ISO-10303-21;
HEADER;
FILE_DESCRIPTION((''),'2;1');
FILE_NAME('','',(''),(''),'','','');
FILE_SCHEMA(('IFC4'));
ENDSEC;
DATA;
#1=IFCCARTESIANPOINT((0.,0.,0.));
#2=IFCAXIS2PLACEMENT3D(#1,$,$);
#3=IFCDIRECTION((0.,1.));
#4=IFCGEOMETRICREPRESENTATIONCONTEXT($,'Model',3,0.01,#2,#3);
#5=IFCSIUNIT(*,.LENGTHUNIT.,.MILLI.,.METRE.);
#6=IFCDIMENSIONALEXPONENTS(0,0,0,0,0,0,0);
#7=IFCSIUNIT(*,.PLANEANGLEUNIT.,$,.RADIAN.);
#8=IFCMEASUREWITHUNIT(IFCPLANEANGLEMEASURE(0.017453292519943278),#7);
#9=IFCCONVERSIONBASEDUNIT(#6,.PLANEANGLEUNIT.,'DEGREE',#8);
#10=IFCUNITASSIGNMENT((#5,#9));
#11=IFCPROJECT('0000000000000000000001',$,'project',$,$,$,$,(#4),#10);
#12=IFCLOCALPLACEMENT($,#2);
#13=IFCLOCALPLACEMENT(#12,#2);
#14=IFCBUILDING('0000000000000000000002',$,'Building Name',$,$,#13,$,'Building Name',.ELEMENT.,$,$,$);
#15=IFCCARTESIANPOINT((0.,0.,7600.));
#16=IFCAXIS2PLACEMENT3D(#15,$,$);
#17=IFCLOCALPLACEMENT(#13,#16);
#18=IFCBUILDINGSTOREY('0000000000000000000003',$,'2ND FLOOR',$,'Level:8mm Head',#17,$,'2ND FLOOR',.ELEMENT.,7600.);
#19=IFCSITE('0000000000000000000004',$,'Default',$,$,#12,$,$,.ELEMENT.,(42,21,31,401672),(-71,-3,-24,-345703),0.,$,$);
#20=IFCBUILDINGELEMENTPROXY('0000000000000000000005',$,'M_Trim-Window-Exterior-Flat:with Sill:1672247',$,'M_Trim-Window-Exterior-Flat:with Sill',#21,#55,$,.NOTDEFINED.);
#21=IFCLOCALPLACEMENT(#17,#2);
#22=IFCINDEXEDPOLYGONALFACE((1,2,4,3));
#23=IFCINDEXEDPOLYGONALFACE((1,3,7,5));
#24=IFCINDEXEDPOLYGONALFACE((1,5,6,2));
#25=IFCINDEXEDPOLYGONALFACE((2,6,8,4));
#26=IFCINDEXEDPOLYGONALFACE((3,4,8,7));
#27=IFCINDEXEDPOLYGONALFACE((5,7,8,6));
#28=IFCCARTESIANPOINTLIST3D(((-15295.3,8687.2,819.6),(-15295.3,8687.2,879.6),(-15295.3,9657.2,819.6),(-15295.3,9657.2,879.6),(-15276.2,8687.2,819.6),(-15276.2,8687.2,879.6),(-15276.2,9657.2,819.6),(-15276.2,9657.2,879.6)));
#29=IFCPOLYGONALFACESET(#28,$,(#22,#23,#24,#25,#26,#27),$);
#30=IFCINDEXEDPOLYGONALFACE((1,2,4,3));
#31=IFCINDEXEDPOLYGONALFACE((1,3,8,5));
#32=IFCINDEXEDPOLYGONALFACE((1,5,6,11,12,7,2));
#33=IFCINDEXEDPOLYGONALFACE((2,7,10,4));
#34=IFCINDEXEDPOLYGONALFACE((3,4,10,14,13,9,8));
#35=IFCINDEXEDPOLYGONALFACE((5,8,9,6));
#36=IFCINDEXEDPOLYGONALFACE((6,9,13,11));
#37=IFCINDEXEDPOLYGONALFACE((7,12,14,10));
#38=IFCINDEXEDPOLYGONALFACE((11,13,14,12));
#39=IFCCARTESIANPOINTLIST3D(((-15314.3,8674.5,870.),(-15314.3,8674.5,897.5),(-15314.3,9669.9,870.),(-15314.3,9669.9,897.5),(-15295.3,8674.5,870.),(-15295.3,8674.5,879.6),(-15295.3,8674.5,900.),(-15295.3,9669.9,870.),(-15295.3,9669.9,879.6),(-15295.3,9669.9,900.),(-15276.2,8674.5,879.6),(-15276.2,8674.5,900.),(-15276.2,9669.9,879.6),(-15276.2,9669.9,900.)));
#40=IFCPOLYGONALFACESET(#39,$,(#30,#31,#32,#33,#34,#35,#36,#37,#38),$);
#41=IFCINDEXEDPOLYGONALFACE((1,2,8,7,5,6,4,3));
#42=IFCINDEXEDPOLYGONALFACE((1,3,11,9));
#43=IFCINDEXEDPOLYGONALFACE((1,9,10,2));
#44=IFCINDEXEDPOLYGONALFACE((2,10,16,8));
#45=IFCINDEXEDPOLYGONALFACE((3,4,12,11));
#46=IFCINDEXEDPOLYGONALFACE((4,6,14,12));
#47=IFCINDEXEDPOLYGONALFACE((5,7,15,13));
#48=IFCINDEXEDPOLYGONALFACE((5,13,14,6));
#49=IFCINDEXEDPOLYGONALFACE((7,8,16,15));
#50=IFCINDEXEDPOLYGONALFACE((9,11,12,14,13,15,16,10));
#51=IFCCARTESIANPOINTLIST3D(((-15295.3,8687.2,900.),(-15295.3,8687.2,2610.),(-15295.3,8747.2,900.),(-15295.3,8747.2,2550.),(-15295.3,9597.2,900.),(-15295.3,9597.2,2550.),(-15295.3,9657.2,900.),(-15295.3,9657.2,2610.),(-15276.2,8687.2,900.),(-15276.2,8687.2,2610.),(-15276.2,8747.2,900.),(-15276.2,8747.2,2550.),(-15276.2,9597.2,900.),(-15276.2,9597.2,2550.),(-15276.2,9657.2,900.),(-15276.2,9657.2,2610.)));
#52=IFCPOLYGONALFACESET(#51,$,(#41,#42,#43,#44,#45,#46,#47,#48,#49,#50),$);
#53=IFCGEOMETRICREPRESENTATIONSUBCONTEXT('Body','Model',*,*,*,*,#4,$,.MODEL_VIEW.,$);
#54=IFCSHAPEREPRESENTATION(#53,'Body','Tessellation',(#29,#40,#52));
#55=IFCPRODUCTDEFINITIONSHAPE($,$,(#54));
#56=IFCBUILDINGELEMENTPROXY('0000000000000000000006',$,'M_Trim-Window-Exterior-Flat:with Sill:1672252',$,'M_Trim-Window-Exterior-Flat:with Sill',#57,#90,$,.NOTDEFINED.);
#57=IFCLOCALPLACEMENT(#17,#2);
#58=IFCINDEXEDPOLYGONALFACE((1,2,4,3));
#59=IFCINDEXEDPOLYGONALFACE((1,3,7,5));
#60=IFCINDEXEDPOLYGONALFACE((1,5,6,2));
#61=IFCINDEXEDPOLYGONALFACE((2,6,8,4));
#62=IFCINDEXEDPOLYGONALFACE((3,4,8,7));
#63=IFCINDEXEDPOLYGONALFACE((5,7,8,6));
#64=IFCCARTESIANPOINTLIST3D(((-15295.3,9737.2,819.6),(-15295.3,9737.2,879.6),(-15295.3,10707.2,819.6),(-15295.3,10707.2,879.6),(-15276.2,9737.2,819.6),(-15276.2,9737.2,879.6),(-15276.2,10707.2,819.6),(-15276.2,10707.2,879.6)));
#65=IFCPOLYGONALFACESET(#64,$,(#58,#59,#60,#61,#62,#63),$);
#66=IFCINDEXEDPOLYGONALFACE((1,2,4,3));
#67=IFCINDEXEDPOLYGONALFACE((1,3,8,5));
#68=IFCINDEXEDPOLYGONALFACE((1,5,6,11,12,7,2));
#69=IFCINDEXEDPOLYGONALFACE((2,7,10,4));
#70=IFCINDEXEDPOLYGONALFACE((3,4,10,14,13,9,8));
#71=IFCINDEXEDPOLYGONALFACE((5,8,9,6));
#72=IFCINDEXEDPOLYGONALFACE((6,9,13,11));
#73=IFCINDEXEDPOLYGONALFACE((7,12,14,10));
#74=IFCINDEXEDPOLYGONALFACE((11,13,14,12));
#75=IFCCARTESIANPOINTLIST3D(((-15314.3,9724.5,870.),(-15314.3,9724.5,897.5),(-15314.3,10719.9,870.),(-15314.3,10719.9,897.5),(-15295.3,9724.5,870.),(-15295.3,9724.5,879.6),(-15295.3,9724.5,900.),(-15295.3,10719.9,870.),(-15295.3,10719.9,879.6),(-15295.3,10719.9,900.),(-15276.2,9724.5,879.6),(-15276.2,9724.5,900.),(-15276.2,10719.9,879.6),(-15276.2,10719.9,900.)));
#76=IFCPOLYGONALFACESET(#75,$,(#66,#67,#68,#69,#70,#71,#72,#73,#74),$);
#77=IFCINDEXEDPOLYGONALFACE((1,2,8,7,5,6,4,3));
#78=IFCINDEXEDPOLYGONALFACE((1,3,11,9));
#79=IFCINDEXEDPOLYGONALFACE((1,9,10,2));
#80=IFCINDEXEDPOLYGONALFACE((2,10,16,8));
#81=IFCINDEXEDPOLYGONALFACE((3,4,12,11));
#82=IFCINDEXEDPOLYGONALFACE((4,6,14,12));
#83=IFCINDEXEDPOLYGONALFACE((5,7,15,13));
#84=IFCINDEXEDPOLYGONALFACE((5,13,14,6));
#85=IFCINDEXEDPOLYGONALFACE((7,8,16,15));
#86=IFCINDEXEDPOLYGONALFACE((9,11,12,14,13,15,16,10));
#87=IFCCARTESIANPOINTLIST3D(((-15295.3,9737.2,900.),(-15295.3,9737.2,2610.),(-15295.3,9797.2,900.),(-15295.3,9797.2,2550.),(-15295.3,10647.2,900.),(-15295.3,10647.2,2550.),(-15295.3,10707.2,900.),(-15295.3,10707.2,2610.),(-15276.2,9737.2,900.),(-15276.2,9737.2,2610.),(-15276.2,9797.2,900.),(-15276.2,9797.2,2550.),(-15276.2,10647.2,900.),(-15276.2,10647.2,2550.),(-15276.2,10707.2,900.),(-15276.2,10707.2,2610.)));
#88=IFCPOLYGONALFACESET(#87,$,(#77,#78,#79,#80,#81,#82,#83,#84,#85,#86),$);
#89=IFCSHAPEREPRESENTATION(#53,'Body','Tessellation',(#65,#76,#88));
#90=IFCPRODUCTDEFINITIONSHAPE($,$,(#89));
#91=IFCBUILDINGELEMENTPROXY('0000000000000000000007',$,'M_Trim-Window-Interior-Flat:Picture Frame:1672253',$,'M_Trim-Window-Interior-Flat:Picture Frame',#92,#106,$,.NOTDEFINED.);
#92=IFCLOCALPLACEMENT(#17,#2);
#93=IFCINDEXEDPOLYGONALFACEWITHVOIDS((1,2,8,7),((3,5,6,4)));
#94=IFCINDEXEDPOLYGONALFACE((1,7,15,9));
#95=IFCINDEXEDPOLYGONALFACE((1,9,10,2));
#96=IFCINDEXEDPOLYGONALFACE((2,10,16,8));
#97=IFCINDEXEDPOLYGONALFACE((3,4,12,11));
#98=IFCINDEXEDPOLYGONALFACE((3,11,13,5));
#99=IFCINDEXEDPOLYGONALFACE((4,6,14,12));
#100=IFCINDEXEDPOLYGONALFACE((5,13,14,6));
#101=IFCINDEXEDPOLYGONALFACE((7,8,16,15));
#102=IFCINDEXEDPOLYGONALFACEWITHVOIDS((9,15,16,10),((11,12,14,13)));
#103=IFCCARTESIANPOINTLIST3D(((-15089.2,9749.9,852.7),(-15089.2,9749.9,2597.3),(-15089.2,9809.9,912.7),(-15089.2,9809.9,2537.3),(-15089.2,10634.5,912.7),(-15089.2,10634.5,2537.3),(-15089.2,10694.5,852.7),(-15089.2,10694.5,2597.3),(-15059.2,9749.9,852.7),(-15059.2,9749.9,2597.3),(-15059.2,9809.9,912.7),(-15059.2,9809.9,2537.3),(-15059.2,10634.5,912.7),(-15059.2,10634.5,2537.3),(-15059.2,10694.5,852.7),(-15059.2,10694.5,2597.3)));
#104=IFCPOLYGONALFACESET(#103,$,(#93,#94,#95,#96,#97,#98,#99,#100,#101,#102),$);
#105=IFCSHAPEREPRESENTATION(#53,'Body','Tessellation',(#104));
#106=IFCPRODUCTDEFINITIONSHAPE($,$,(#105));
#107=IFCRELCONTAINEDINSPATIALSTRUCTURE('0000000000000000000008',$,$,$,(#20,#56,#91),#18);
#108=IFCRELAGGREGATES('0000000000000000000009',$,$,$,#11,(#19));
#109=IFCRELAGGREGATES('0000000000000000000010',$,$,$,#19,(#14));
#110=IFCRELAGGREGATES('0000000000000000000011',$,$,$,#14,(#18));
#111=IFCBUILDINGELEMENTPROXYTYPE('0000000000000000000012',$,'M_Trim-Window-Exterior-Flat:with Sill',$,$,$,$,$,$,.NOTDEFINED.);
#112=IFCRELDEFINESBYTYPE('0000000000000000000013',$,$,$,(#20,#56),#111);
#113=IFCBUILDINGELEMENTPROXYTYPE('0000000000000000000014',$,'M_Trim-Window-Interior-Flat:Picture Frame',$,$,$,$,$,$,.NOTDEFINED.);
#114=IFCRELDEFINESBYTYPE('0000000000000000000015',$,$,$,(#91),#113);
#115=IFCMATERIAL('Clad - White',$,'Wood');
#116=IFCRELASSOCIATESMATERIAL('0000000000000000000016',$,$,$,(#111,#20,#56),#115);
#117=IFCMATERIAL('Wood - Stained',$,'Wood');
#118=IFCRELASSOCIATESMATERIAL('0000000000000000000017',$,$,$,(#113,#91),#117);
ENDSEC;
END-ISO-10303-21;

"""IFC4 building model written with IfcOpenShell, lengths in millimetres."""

from ifc_helpers import new_model, entity, si_unit, converted_unit, direction, frame, origin, place, context, subcontext, project, spatial, indexed_curve, outline, extrude, source, transform, mapped, material, type_object, type_shapes, element, save


model = new_model("IFC4")

# Units and contexts
model_context = context("Model", 3, precision=0.01, world=origin(), true_north=direction((0.0, 1.0)))
body_context = subcontext(model_context, "Body", "Model", "MODEL_VIEW")
ifc_project = project(units=[si_unit("LENGTHUNIT", "METRE", prefix="MILLI"), converted_unit("PLANEANGLEUNIT", "DEGREE", entity("IfcPlaneAngleMeasure", 0.017453292519943278), si_unit("PLANEANGLEUNIT", "RADIAN"), dimensions=[0, 0, 0, 0, 0, 0, 0])], contexts=[model_context])

# Site, building, storey
site_placement = place(None, origin())
site = spatial("IfcSite", under=ifc_project, at=site_placement, Name="Default", CompositionType="ELEMENT", RefLatitude=(42, 21, 31, 401672), RefLongitude=(-71, -3, -24, -345703), RefElevation=0.0)
building_placement = place(site_placement, origin())
building = spatial("IfcBuilding", under=site, at=building_placement, Name="Building Name", LongName="Building Name", CompositionType="ELEMENT")
storey_placement = place(building_placement, frame((0.0, 0.0, 7600.0)))
storey = spatial("IfcBuildingStorey", under=building, at=storey_placement, Name="2ND FLOOR", ObjectType="Level:8mm Head", LongName="2ND FLOOR", CompositionType="ELEMENT", Elevation=7600.0)

# Shared definitions
ifc_material_1 = material(Name="Wood - Stained", Category="Wood")

# Building element proxies
ifc_material_2 = material(Name="Clad - White", Category="Wood")
building_element_proxy_type_1 = type_object("IfcBuildingElementProxyType", Name="M_Trim-Window-Exterior-Flat:with Sill", PredefinedType="NOTDEFINED", material=ifc_material_2)
shared_shape_1 = source(origin(), body_context, "Body", "SweptSolid", [
    extrude(outline(indexed_curve([(-485.0, -30.0), (485.0, -30.0), (485.0, 30.0), (-485.0, 30.0), (-485.0, -30.0)], self_intersect=False)), frame((0.0, -1700.4, 0.0), z_axis=(0.0, 0.0, 1.0), x_axis=(-1.0, 0.0, 0.0)), (0.0, 0.0, 1.0), 19.0),
    extrude(outline(indexed_curve([(-19.0, -15.2), (0.0, -15.2), (0.0, -5.7), (19.0, -5.7), (19.0, 14.8), (0.0, 14.8), (-19.0, 12.3), (-19.0, -15.2)], self_intersect=False)), frame((-497.7, -1664.8, 19.0), z_axis=(1.0, 0.0, 0.0), x_axis=(0.0, 0.0, -1.0)), (0.0, 0.0, 1.0), 995.4),
    extrude(outline(indexed_curve([(-870.0, -485.0), (840.0, -485.0), (840.0, -425.0), (-810.0, -425.0), (-810.0, 425.0), (840.0, 425.0), (840.0, 485.0), (-870.0, 485.0), (-870.0, -485.0)], self_intersect=False)), frame((0.0, -810.0, 0.0), z_axis=(0.0, 0.0, 1.0), x_axis=(0.0, -1.0, 0.0)), (0.0, 0.0, 1.0), 19.0),
])
type_shapes(building_element_proxy_type_1, [shared_shape_1])
for number, where, z_axis, x_axis, name in (
    (1, (-15276.2, 9172.2, 2550.0), (-1.0, 0.0, 0.0), (0.0, -1.0, 0.0), "M_Trim-Window-Exterior-Flat:with Sill:1672247"),
    (2, (-15276.2, 10222.2, 2550.0), (-1.0, 0.0, 0.0), (0.0, -1.0, 0.0), "M_Trim-Window-Exterior-Flat:with Sill:1672252"),
):
    element("IfcBuildingElementProxy", number, at=place(storey_placement, frame(where, z_axis=z_axis, x_axis=x_axis)), inside=storey, type_object=building_element_proxy_type_1, material=ifc_material_2, Name=name, ObjectType="M_Trim-Window-Exterior-Flat:with Sill", PredefinedType="NOTDEFINED", context=body_context, shape_type="MappedRepresentation", body=[
        mapped(shared_shape_1, transform((0.0, 0.0, 0.0), scale=1.0)),
    ])
building_element_proxy_type_2 = type_object("IfcBuildingElementProxyType", Name="M_Trim-Window-Interior-Flat:Picture Frame", PredefinedType="NOTDEFINED", material=ifc_material_1)
shared_shape_2 = source(origin(), body_context, "Body", "SweptSolid", [
    extrude(outline(indexed_curve([(-472.3, -872.3), (472.3, -872.3), (472.3, 872.3), (-472.3, 872.3), (-472.3, -872.3)], self_intersect=False), holes=[indexed_curve([(-412.3, -812.3), (-412.3, 812.3), (412.3, 812.3), (412.3, -812.3), (-412.3, -812.3)], self_intersect=False)]), frame((0.0, -825.0, 0.0), z_axis=(0.0, 0.0, 1.0), x_axis=(-1.0, 0.0, 0.0)), (0.0, 0.0, 1.0), 30.0),
])
type_shapes(building_element_proxy_type_2, [shared_shape_2])
proxy_1_placement = place(storey_placement, frame((-15089.2, 10222.2, 2550.0), z_axis=(1.0, 0.0, 0.0), x_axis=(0.0, 1.0, 0.0)))
element("IfcBuildingElementProxy", 3, at=proxy_1_placement, inside=storey, type_object=building_element_proxy_type_2, material=ifc_material_1, Name="M_Trim-Window-Interior-Flat:Picture Frame:1672253", ObjectType="M_Trim-Window-Interior-Flat:Picture Frame", PredefinedType="NOTDEFINED", context=body_context, shape_type="MappedRepresentation", body=[
    mapped(shared_shape_2, transform((0.0, 0.0, 0.0), scale=1.0)),
])

save(model, "model.ifc")
